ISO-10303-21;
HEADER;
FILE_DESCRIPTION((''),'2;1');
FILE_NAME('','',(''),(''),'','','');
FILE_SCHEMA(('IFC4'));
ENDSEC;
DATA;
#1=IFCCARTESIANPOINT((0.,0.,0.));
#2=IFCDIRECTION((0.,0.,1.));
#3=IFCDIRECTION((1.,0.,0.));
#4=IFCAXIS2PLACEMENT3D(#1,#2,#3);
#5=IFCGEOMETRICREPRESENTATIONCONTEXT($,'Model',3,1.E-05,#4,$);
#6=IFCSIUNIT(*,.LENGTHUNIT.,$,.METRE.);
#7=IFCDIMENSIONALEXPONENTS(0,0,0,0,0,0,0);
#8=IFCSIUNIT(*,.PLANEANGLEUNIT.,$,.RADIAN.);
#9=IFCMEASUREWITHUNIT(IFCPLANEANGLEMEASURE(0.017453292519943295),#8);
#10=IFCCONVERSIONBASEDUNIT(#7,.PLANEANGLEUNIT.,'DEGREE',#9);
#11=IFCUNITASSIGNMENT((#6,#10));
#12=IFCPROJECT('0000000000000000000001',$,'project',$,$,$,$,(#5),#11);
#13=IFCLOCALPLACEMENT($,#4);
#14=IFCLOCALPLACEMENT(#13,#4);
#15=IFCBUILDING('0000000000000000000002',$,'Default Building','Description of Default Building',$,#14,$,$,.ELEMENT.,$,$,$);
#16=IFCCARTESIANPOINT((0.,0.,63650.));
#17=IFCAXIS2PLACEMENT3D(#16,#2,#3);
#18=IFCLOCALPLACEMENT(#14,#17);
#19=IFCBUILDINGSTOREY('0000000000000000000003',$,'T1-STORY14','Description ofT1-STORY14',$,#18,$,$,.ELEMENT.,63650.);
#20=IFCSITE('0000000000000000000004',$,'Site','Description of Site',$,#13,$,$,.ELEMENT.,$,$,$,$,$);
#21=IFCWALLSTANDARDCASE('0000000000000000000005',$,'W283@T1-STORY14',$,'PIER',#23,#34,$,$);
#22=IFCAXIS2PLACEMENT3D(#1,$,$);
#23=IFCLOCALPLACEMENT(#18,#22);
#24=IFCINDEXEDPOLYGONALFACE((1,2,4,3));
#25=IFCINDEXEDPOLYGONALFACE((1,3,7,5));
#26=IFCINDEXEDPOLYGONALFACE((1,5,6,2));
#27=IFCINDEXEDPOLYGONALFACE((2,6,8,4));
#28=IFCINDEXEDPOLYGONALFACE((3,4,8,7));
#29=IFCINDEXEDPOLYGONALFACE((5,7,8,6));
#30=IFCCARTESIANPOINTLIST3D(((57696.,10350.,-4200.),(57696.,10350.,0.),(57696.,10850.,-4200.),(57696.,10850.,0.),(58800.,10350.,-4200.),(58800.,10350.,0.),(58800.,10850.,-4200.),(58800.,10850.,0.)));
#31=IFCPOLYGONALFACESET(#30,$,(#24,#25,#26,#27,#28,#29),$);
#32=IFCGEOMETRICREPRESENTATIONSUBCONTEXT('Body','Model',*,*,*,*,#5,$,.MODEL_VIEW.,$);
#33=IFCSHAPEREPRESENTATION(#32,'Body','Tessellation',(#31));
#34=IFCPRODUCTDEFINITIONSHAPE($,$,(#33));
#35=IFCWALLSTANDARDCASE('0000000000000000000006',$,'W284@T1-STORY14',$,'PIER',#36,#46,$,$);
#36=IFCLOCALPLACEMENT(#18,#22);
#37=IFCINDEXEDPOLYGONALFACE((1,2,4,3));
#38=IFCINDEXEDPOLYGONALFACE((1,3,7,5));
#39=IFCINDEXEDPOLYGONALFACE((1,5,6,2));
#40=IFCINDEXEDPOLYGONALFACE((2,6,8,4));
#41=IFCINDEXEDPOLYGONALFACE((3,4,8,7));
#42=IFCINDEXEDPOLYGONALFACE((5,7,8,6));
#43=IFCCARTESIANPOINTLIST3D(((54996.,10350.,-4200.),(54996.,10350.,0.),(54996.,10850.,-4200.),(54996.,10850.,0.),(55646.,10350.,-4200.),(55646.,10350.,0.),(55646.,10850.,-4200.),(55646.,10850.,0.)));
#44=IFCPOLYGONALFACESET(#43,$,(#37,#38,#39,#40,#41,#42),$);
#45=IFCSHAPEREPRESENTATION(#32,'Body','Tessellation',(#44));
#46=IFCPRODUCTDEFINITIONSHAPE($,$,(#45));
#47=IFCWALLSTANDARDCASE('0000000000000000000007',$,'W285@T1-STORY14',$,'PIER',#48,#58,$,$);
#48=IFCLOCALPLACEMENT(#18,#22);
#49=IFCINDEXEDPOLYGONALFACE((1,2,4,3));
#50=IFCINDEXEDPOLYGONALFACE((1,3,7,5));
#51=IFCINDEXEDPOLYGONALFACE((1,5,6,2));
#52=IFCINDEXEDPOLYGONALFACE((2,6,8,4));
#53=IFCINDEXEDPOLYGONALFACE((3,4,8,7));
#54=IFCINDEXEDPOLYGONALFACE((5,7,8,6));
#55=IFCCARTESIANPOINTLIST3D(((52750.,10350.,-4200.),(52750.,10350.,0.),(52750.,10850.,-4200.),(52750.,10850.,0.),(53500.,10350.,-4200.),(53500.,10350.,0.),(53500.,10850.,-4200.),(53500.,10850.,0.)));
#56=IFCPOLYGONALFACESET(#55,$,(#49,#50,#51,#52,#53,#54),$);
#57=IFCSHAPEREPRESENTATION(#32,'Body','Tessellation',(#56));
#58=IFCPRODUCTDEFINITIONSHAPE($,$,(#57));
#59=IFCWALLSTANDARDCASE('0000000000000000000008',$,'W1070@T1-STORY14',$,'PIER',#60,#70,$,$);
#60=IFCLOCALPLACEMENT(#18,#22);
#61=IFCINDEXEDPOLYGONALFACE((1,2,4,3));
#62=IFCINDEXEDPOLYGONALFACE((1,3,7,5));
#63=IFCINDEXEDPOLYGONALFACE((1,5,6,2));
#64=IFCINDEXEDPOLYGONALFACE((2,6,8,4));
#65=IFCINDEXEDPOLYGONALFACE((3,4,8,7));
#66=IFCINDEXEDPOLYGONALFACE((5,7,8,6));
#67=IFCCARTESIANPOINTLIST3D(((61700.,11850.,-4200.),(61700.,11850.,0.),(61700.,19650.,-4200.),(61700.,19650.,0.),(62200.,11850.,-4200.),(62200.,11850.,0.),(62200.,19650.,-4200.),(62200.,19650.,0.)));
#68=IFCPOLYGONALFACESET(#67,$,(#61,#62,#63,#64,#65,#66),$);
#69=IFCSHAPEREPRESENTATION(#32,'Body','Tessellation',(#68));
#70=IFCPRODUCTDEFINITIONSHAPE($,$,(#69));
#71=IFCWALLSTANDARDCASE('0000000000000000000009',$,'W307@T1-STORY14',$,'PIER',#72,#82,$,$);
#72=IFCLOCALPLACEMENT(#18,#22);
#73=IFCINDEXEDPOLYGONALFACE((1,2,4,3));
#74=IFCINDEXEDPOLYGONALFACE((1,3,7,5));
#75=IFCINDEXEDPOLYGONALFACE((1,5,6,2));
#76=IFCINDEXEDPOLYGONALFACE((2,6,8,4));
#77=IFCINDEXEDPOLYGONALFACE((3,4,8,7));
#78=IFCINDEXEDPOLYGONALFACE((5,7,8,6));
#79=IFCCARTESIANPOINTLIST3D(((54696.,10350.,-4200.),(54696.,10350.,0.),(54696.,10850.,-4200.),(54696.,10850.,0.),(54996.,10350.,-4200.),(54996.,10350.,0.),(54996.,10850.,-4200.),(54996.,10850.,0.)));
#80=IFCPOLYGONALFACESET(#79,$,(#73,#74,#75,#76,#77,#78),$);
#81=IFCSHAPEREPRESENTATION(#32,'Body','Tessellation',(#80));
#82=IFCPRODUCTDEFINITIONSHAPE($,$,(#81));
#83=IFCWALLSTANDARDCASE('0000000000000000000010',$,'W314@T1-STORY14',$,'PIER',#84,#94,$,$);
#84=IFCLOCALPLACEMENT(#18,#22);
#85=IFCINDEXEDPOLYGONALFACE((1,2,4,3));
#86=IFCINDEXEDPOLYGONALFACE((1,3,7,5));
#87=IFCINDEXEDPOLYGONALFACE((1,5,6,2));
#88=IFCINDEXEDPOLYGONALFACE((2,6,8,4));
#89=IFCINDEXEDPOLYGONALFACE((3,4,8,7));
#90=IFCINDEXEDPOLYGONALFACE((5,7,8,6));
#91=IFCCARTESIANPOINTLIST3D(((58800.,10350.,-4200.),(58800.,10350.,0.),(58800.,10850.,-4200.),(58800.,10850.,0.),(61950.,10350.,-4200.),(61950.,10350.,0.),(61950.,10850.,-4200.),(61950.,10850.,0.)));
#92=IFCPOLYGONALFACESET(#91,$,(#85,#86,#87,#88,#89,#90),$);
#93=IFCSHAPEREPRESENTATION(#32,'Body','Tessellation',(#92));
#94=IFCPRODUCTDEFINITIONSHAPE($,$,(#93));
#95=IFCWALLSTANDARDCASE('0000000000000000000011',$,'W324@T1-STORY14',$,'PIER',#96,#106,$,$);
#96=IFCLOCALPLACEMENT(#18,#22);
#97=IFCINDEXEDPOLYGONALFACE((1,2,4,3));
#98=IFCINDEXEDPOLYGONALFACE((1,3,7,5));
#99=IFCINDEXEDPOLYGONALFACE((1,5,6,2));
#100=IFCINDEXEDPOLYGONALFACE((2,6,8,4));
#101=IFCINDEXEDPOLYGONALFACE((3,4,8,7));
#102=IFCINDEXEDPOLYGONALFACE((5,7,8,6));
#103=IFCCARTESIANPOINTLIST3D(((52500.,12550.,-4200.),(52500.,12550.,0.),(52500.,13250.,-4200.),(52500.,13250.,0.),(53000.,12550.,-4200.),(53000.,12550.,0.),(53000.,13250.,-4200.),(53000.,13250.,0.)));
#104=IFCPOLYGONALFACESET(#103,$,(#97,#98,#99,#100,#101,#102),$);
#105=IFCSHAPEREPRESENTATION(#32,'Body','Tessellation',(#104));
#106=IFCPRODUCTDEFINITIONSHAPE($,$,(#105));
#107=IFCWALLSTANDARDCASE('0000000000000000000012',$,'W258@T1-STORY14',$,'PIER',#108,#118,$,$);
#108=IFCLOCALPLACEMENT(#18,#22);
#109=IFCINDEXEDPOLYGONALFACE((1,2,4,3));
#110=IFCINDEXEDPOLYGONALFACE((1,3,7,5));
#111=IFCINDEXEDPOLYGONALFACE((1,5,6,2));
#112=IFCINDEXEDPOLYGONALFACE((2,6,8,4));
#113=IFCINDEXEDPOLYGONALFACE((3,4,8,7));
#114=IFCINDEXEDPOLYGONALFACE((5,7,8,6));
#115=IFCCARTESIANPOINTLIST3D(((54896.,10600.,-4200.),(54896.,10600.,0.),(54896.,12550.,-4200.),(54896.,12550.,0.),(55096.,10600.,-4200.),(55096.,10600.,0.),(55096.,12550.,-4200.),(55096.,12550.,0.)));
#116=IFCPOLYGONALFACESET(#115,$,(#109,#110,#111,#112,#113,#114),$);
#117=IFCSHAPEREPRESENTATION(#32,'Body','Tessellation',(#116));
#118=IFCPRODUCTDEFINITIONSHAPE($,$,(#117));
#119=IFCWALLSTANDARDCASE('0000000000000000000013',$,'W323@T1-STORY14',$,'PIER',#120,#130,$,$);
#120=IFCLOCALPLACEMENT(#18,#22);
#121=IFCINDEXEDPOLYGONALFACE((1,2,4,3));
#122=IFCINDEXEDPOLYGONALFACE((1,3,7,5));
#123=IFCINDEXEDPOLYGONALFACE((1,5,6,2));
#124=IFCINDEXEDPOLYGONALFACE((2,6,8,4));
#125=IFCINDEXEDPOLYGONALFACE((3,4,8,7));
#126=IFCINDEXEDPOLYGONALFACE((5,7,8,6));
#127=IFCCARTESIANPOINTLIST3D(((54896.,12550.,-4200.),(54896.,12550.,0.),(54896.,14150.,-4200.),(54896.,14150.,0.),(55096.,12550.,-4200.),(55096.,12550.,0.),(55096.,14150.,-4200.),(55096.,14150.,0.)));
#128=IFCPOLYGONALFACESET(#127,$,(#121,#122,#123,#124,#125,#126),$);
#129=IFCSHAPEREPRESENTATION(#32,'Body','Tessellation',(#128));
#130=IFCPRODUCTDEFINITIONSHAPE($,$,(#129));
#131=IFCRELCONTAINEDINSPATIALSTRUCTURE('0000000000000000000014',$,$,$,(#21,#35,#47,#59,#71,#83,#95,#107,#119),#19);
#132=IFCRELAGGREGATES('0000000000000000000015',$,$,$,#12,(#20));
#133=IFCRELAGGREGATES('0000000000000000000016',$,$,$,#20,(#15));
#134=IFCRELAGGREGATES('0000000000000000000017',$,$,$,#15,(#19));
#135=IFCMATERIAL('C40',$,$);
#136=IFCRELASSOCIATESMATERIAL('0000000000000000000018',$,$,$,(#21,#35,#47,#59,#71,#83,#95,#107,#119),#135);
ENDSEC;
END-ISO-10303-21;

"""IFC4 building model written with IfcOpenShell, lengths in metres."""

from ifc_helpers import new_model, entity, si_unit, converted_unit, frame, origin_with_axes, place, context, subcontext, project, spatial, indexed_curve, outline, extrude, material, element, save


model = new_model("IFC4")

# Units and contexts
model_context = context("Model", 3, precision=1e-05, world=origin_with_axes())
body_context = subcontext(model_context, "Body", "Model", "MODEL_VIEW")
ifc_project = project(units=[si_unit("LENGTHUNIT", "METRE"), converted_unit("PLANEANGLEUNIT", "DEGREE", entity("IfcPlaneAngleMeasure", 0.017453292519943295), si_unit("PLANEANGLEUNIT", "RADIAN"), dimensions=[0, 0, 0, 0, 0, 0, 0])], contexts=[model_context])

# Site, building, storey
site_placement = place(None, origin_with_axes())
site = spatial("IfcSite", under=ifc_project, at=site_placement, Name="Site", Description="Description of Site", CompositionType="ELEMENT")
building_placement = place(site_placement, origin_with_axes())
building = spatial("IfcBuilding", under=site, at=building_placement, Name="Default Building", Description="Description of Default Building", CompositionType="ELEMENT")
storey_placement = place(building_placement, frame((0.0, 0.0, 63650.0), z_axis=(0.0, 0.0, 1.0), x_axis=(1.0, 0.0, 0.0)))
storey = spatial("IfcBuildingStorey", under=building, at=storey_placement, Name="T1-STORY14", Description="Description ofT1-STORY14", CompositionType="ELEMENT", Elevation=63650.0)

# Walls
ifc_material_1 = material(Name="C40")
wall_1_placement = place(storey_placement, frame((57696.0, 10600.0, -4200.0), z_axis=(0.0, 0.0, 1.0), x_axis=(1.0, 0.0, 0.0)))
element("IfcWallStandardCase", 1, at=wall_1_placement, inside=storey, material=ifc_material_1, Name="W283@T1-STORY14", ObjectType="PIER", context=body_context, shape_type="SweptSolid", body=[
    extrude(outline(indexed_curve([(0.0, -250.0), (0.0, 250.0), (1104.0, 250.0), (1104.0, -250.0), (0.0, -250.0)], self_intersect=False)), origin_with_axes(), (0.0, 0.0, 1.0), 4200.0),
])
wall_2_placement = place(storey_placement, frame((54996.0, 10600.0, -4200.0), z_axis=(0.0, 0.0, 1.0), x_axis=(1.0, 0.0, 0.0)))
element("IfcWallStandardCase", 2, at=wall_2_placement, inside=storey, material=ifc_material_1, Name="W284@T1-STORY14", ObjectType="PIER", context=body_context, shape_type="SweptSolid", body=[
    extrude(outline(indexed_curve([(0.0, -250.0), (0.0, 250.0), (650.0, 250.0), (650.0, -250.0), (0.0, -250.0)], self_intersect=False)), origin_with_axes(), (0.0, 0.0, 1.0), 4200.0),
])
wall_3_placement = place(storey_placement, frame((52750.0, 10600.0, -4200.0), z_axis=(0.0, 0.0, 1.0), x_axis=(1.0, 0.0, 0.0)))
element("IfcWallStandardCase", 3, at=wall_3_placement, inside=storey, material=ifc_material_1, Name="W285@T1-STORY14", ObjectType="PIER", context=body_context, shape_type="SweptSolid", body=[
    extrude(outline(indexed_curve([(0.0, -250.0), (0.0, 250.0), (750.0, 250.0), (750.0, -250.0), (0.0, -250.0)], self_intersect=False)), origin_with_axes(), (0.0, 0.0, 1.0), 4200.0),
])
wall_4_placement = place(storey_placement, frame((61950.0, 11850.0, -4200.0), z_axis=(0.0, 0.0, 1.0), x_axis=(0.0, 1.0, 0.0)))
element("IfcWallStandardCase", 4, at=wall_4_placement, inside=storey, material=ifc_material_1, Name="W1070@T1-STORY14", ObjectType="PIER", context=body_context, shape_type="SweptSolid", body=[
    extrude(outline(indexed_curve([(0.0, -250.0), (0.0, 250.0), (7800.0, 250.0), (7800.0, -250.0), (0.0, -250.0)], self_intersect=False)), origin_with_axes(), (0.0, 0.0, 1.0), 4200.0),
])
wall_5_placement = place(storey_placement, frame((54696.0, 10600.0, -4200.0), z_axis=(0.0, 0.0, 1.0), x_axis=(1.0, 0.0, 0.0)))
element("IfcWallStandardCase", 5, at=wall_5_placement, inside=storey, material=ifc_material_1, Name="W307@T1-STORY14", ObjectType="PIER", context=body_context, shape_type="SweptSolid", body=[
    extrude(outline(indexed_curve([(0.0, -250.0), (0.0, 250.0), (300.0, 250.0), (300.0, -250.0), (0.0, -250.0)], self_intersect=False)), origin_with_axes(), (0.0, 0.0, 1.0), 4200.0),
])
wall_6_placement = place(storey_placement, frame((58800.0, 10600.0, -4200.0), z_axis=(0.0, 0.0, 1.0), x_axis=(1.0, 0.0, 0.0)))
element("IfcWallStandardCase", 6, at=wall_6_placement, inside=storey, material=ifc_material_1, Name="W314@T1-STORY14", ObjectType="PIER", context=body_context, shape_type="SweptSolid", body=[
    extrude(outline(indexed_curve([(0.0, -250.0), (0.0, 250.0), (3150.0, 250.0), (3150.0, -250.0), (0.0, -250.0)], self_intersect=False)), origin_with_axes(), (0.0, 0.0, 1.0), 4200.0),
])
wall_7_placement = place(storey_placement, frame((52750.0, 12550.0, -4200.0), z_axis=(0.0, 0.0, 1.0), x_axis=(0.0, 1.0, 0.0)))
element("IfcWallStandardCase", 7, at=wall_7_placement, inside=storey, material=ifc_material_1, Name="W324@T1-STORY14", ObjectType="PIER", context=body_context, shape_type="SweptSolid", body=[
    extrude(outline(indexed_curve([(0.0, -250.0), (0.0, 250.0), (700.0, 250.0), (700.0, -250.0), (0.0, -250.0)], self_intersect=False)), origin_with_axes(), (0.0, 0.0, 1.0), 4200.0),
])
wall_8_placement = place(storey_placement, frame((54996.0, 10600.0, -4200.0), z_axis=(0.0, 0.0, 1.0), x_axis=(0.0, 1.0, 0.0)))
element("IfcWallStandardCase", 8, at=wall_8_placement, inside=storey, material=ifc_material_1, Name="W258@T1-STORY14", ObjectType="PIER", context=body_context, shape_type="SweptSolid", body=[
    extrude(outline(indexed_curve([(0.0, -100.0), (0.0, 100.0), (1950.0, 100.0), (1950.0, -100.0), (0.0, -100.0)], self_intersect=False)), origin_with_axes(), (0.0, 0.0, 1.0), 4200.0),
])
wall_9_placement = place(storey_placement, frame((54996.0, 12550.0, -4200.0), z_axis=(0.0, 0.0, 1.0), x_axis=(0.0, 1.0, 0.0)))
element("IfcWallStandardCase", 9, at=wall_9_placement, inside=storey, material=ifc_material_1, Name="W323@T1-STORY14", ObjectType="PIER", context=body_context, shape_type="SweptSolid", body=[
    extrude(outline(indexed_curve([(0.0, -100.0), (0.0, 100.0), (1600.0, 100.0), (1600.0, -100.0), (0.0, -100.0)], self_intersect=False)), origin_with_axes(), (0.0, 0.0, 1.0), 4200.0),
])

save(model, "model.ifc")
